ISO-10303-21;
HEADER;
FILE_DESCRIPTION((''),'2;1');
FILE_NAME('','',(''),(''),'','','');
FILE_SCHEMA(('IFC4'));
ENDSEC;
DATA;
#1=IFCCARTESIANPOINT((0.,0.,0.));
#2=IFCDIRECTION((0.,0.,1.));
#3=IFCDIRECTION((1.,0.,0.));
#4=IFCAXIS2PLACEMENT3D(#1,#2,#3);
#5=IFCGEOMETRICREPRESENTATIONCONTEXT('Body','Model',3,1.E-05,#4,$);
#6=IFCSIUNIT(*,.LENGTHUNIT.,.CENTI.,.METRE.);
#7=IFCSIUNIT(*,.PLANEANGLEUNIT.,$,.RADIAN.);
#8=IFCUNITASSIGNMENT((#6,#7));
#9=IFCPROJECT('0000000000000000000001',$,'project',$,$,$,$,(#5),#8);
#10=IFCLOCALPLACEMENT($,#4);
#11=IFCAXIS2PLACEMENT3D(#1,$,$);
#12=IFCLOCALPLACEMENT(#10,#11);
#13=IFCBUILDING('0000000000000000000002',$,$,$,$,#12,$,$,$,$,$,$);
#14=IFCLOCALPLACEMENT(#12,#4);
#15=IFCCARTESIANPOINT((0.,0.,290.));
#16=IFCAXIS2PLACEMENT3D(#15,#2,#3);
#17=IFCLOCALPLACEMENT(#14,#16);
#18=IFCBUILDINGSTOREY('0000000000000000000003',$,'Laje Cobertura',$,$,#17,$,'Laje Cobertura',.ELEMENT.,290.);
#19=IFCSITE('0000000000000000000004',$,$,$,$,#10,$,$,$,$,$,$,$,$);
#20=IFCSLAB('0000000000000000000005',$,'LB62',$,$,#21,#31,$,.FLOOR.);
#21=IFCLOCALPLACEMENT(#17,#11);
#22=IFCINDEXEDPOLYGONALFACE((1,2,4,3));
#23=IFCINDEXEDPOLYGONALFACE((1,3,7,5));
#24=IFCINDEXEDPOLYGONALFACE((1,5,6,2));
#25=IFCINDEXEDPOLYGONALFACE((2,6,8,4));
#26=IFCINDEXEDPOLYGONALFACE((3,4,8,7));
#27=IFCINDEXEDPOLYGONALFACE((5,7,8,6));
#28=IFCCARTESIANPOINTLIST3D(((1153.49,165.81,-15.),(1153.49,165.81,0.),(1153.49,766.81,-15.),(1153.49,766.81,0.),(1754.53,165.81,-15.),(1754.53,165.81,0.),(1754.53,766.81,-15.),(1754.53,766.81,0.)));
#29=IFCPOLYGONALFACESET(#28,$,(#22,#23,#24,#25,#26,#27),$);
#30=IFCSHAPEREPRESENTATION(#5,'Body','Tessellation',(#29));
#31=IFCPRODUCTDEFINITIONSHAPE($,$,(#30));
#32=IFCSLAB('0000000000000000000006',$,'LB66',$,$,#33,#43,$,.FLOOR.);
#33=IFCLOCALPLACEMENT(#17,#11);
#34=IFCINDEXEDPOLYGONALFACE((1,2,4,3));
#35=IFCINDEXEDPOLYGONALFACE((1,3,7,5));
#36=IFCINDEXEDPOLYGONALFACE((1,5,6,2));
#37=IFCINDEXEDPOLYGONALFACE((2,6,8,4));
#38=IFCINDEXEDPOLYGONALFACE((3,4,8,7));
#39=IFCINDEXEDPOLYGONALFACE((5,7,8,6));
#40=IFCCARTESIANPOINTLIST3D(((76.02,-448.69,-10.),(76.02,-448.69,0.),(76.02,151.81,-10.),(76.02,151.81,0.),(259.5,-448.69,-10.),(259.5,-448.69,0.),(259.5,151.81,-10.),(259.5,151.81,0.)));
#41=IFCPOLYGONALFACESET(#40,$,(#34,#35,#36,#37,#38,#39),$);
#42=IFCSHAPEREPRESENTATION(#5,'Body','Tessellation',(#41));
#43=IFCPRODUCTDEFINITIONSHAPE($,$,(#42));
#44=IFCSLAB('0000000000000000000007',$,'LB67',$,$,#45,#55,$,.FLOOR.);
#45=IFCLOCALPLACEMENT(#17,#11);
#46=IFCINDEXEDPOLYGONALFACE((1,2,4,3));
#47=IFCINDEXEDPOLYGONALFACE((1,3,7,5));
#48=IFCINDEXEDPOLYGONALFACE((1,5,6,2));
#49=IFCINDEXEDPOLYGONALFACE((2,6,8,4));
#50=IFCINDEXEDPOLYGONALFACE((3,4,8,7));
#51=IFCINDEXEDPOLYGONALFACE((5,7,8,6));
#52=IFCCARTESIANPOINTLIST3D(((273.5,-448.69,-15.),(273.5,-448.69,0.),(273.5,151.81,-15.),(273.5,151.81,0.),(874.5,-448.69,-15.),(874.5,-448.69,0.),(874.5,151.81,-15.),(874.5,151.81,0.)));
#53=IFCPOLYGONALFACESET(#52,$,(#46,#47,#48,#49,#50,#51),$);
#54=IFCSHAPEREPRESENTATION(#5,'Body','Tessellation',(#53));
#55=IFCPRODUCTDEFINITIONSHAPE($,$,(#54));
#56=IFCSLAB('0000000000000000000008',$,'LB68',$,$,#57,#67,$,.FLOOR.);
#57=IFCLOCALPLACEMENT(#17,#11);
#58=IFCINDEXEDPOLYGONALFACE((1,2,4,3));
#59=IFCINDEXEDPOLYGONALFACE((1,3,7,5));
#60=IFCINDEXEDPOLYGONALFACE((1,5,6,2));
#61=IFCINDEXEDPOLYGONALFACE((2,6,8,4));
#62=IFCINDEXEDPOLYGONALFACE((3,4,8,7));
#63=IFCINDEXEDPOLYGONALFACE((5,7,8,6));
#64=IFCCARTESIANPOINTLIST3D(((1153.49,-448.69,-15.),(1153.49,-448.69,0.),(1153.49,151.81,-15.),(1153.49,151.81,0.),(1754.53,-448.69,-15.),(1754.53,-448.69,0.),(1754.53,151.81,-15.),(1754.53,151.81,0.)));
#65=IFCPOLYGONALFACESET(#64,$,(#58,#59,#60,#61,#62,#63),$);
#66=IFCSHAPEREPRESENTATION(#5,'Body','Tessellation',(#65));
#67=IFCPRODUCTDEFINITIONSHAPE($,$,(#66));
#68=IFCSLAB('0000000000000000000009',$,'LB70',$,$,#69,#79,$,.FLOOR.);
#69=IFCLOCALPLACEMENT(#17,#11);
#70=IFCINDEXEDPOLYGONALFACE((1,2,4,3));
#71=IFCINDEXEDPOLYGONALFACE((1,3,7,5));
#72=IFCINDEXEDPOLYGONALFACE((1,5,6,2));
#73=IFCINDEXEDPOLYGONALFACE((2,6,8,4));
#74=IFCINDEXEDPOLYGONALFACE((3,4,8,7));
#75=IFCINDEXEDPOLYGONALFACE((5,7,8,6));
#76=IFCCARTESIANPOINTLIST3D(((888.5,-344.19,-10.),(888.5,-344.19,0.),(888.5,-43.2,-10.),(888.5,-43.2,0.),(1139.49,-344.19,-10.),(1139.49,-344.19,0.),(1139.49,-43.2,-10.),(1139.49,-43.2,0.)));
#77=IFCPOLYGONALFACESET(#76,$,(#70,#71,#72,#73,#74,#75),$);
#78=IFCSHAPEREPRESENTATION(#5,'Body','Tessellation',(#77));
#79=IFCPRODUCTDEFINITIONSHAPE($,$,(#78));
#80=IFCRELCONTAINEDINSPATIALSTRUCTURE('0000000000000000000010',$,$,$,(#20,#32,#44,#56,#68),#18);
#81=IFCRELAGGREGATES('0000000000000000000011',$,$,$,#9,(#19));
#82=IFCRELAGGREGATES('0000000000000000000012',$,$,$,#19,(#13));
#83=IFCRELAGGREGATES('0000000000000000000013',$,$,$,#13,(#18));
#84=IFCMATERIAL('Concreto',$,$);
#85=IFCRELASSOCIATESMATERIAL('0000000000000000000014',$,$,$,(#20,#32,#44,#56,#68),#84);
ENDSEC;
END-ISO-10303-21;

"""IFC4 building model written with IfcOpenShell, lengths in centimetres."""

from ifc_helpers import new_model, si_unit, frame, origin, origin_with_axes, place, context, project, spatial, polyline, outline, extrude, material, element, save


model = new_model("IFC4")

# Units and contexts
model_context = context("Model", 3, precision=1e-05, world=origin_with_axes(), identifier="Body")
ifc_project = project(units=[si_unit("LENGTHUNIT", "METRE", prefix="CENTI"), si_unit("PLANEANGLEUNIT", "RADIAN")], contexts=[model_context])

# Site, building, storey
site_placement = place(None, origin_with_axes())
site = spatial("IfcSite", under=ifc_project, at=site_placement)
building_placement = place(site_placement, origin())
building = spatial("IfcBuilding", under=site, at=building_placement)
placement = place(building_placement, origin_with_axes())
storey_placement = place(placement, frame((0.0, 0.0, 290.0), z_axis=(0.0, 0.0, 1.0), x_axis=(1.0, 0.0, 0.0)))
storey = spatial("IfcBuildingStorey", under=building, at=storey_placement, Name="Laje Cobertura", LongName="Laje Cobertura", CompositionType="ELEMENT", Elevation=290.0)

# Shared definitions
ifc_material = material(Name="Concreto")

# Slabs
slab_1_placement = place(storey_placement, frame((1454.01, 466.31, 0.0), z_axis=(0.0, 0.0, 1.0), x_axis=(1.0, 0.0, 0.0)))
element("IfcSlab", 1, at=slab_1_placement, inside=storey, material=ifc_material, Name="LB62", PredefinedType="FLOOR", context=model_context, shape_type="SolidModel", body=[
    extrude(outline(polyline([(300.52, -300.5), (300.52, 300.5), (-300.52, 300.5), (-300.52, -300.5), (300.52, -300.5), (300.52, -300.5)])), frame((0.0, 0.0, -15.0), z_axis=(0.0, 0.0, 1.0), x_axis=(1.0, 0.0, 0.0)), (0.0, 0.0, 1.0), 15.0),
])
slab_2_placement = place(storey_placement, frame((167.76, -148.44, 0.0), z_axis=(0.0, 0.0, 1.0), x_axis=(1.0, 0.0, 0.0)))
element("IfcSlab", 2, at=slab_2_placement, inside=storey, material=ifc_material, Name="LB66", PredefinedType="FLOOR", context=model_context, shape_type="SolidModel", body=[
    extrude(outline(polyline([(91.74, 300.25), (-91.74, 300.25), (-91.74, -300.25), (91.74, -300.25), (91.74, 300.25), (91.74, 300.25)])), frame((0.0, 0.0, -10.0), z_axis=(0.0, 0.0, 1.0), x_axis=(1.0, 0.0, 0.0)), (0.0, 0.0, 1.0), 10.0),
])
slab_3_placement = place(storey_placement, frame((574.0, -148.44, 0.0), z_axis=(0.0, 0.0, 1.0), x_axis=(1.0, 0.0, 0.0)))
element("IfcSlab", 3, at=slab_3_placement, inside=storey, material=ifc_material, Name="LB67", PredefinedType="FLOOR", context=model_context, shape_type="SolidModel", body=[
    extrude(outline(polyline([(300.5, 300.25), (-300.5, 300.25), (-300.5, -300.25), (300.5, -300.25), (300.5, 300.25), (300.5, 300.25)])), frame((0.0, 0.0, -15.0), z_axis=(0.0, 0.0, 1.0), x_axis=(1.0, 0.0, 0.0)), (0.0, 0.0, 1.0), 15.0),
])
slab_4_placement = place(storey_placement, frame((1454.01, -148.44, 0.0), z_axis=(0.0, 0.0, 1.0), x_axis=(1.0, 0.0, 0.0)))
element("IfcSlab", 4, at=slab_4_placement, inside=storey, material=ifc_material, Name="LB68", PredefinedType="FLOOR", context=model_context, shape_type="SolidModel", body=[
    extrude(outline(polyline([(300.52, -300.25), (300.52, 300.25), (-300.52, 300.25), (-300.52, -300.25), (300.52, -300.25), (300.52, -300.25)])), frame((0.0, 0.0, -15.0), z_axis=(0.0, 0.0, 1.0), x_axis=(1.0, 0.0, 0.0)), (0.0, 0.0, 1.0), 15.0),
])
slab_5_placement = place(storey_placement, frame((1014.0, -193.69, 0.0), z_axis=(0.0, 0.0, 1.0), x_axis=(1.0, 0.0, 0.0)))
element("IfcSlab", 5, at=slab_5_placement, inside=storey, material=ifc_material, Name="LB70", PredefinedType="FLOOR", context=model_context, shape_type="SolidModel", body=[
    extrude(outline(polyline([(125.5, 150.5), (-125.5, 150.5), (-125.5, -150.5), (125.5, -150.5), (125.5, 150.5), (125.5, 150.5)])), frame((0.0, 0.0, -10.0), z_axis=(0.0, 0.0, 1.0), x_axis=(1.0, 0.0, 0.0)), (0.0, 0.0, 1.0), 10.0),
])

save(model, "model.ifc")
